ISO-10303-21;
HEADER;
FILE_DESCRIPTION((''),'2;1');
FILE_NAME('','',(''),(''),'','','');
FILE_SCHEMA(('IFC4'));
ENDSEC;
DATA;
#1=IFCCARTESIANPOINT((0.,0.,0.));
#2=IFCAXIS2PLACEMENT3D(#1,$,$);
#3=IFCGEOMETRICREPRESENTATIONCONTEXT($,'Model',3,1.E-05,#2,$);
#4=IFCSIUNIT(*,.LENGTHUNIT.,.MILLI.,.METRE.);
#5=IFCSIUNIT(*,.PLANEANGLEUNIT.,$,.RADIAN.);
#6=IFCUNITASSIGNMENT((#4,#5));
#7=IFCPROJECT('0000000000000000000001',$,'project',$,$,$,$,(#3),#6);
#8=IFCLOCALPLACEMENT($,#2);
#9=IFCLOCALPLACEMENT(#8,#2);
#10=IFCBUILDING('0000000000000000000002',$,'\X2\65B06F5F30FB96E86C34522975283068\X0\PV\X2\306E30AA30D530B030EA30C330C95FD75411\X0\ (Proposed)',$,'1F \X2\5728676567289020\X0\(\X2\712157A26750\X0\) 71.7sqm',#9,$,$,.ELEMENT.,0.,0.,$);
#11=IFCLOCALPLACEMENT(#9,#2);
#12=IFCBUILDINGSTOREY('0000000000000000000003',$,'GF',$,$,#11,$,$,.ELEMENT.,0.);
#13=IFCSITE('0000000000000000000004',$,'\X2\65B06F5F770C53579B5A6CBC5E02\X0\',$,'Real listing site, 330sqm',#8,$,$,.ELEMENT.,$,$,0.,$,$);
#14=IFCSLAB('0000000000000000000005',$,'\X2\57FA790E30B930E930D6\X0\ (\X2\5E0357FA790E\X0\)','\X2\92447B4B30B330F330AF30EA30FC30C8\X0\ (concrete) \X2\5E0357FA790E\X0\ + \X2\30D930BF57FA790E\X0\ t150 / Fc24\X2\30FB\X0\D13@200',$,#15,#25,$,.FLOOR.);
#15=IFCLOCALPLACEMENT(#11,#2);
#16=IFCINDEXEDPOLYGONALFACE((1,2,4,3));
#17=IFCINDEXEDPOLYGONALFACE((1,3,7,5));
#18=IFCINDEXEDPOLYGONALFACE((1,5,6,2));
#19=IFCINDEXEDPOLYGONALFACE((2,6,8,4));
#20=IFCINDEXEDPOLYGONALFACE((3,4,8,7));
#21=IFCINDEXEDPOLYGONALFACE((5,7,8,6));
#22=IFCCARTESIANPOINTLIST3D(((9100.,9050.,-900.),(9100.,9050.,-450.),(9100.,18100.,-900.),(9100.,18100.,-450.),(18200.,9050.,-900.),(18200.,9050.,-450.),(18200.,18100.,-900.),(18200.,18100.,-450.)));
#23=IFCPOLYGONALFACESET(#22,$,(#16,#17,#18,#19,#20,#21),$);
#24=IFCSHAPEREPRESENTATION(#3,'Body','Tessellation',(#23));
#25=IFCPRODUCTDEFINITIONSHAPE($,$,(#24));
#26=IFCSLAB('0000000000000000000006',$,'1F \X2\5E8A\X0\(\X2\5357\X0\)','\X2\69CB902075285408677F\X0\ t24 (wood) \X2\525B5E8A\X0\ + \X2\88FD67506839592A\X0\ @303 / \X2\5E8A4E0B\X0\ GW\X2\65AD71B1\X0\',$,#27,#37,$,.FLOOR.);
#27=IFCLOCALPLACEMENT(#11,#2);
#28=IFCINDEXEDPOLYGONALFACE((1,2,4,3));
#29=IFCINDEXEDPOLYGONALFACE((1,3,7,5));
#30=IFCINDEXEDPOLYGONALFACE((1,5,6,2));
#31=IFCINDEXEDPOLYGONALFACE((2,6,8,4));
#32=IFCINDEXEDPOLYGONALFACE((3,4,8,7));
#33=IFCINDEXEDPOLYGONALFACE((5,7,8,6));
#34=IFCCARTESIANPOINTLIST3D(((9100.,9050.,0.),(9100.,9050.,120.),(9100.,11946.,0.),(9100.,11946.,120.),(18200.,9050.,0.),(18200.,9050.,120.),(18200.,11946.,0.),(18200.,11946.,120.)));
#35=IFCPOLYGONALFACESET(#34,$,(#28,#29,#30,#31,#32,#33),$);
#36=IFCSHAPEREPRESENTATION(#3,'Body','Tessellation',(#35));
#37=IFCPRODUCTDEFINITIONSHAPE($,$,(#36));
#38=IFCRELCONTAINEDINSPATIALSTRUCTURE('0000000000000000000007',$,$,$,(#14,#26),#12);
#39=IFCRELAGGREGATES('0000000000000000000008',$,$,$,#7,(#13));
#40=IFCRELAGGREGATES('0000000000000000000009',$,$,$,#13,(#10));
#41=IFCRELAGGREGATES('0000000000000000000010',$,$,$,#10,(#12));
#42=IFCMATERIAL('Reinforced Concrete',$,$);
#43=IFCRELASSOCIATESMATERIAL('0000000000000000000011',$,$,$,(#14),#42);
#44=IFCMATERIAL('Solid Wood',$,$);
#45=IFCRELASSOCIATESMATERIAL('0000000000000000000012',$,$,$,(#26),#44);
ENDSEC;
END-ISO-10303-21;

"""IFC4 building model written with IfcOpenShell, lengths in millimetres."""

from ifc_helpers import new_model, si_unit, frame, frame_2d, origin, place, context, project, spatial, rectangle, extrude, material, element, save


model = new_model("IFC4")

# Units and contexts
model_context = context("Model", 3, precision=1e-05, world=origin())
ifc_project = project(units=[si_unit("LENGTHUNIT", "METRE", prefix="MILLI"), si_unit("PLANEANGLEUNIT", "RADIAN")], contexts=[model_context])

# Site, building, storey
site_placement = place(None, origin())
site = spatial("IfcSite", under=ifc_project, at=site_placement, Name="新潟県南魚沼市", ObjectType="Real listing site, 330sqm", CompositionType="ELEMENT", RefElevation=0.0)
building_placement = place(site_placement, origin())
building = spatial("IfcBuilding", under=site, at=building_placement, Name="新潟・雨水利用とPVのオフグリッド志向 (Proposed)", ObjectType="1F 在来木造(無垢材) 71.7sqm", CompositionType="ELEMENT", ElevationOfRefHeight=0.0, ElevationOfTerrain=0.0)
storey_placement = place(building_placement, origin())
storey = spatial("IfcBuildingStorey", under=building, at=storey_placement, Name="GF", CompositionType="ELEMENT", Elevation=0.0)

# Shared definitions
ifc_material_1 = material(Name="Solid Wood")

# Slabs
ifc_material_2 = material(Name="Reinforced Concrete")
slab_1_placement = place(storey_placement, frame((4550.0, 4525.0, -450.0)))
element("IfcSlab", 1, at=slab_1_placement, inside=storey, material=ifc_material_2, Name="基礎スラブ (布基礎)", Description="鉄筋コンクリート (concrete) 布基礎 + ベタ基礎 t150 / Fc24・D13@200", PredefinedType="FLOOR", context=model_context, shape_type="SweptSolid", body=[
    extrude(rectangle(XDim=9100.0, YDim=9050.0, at=frame_2d((4550.0, 4525.0))), frame((4550.0, 4525.0, -450.0)), (0.0, 0.0, 1.0), 450.0),
])
slab_2_placement = place(storey_placement, frame((4550.0, 4525.0, 0.0)))
element("IfcSlab", 2, at=slab_2_placement, inside=storey, material=ifc_material_1, Name="1F 床(南)", Description="構造用合板 t24 (wood) 剛床 + 製材根太 @303 / 床下 GW断熱", PredefinedType="FLOOR", context=model_context, shape_type="SweptSolid", body=[
    extrude(rectangle(XDim=9100.0, YDim=2896.0, at=frame_2d((4550.0, 1448.0))), frame((4550.0, 4525.0, 0.0)), (0.0, 0.0, 1.0), 120.0),
])

save(model, "model.ifc")
